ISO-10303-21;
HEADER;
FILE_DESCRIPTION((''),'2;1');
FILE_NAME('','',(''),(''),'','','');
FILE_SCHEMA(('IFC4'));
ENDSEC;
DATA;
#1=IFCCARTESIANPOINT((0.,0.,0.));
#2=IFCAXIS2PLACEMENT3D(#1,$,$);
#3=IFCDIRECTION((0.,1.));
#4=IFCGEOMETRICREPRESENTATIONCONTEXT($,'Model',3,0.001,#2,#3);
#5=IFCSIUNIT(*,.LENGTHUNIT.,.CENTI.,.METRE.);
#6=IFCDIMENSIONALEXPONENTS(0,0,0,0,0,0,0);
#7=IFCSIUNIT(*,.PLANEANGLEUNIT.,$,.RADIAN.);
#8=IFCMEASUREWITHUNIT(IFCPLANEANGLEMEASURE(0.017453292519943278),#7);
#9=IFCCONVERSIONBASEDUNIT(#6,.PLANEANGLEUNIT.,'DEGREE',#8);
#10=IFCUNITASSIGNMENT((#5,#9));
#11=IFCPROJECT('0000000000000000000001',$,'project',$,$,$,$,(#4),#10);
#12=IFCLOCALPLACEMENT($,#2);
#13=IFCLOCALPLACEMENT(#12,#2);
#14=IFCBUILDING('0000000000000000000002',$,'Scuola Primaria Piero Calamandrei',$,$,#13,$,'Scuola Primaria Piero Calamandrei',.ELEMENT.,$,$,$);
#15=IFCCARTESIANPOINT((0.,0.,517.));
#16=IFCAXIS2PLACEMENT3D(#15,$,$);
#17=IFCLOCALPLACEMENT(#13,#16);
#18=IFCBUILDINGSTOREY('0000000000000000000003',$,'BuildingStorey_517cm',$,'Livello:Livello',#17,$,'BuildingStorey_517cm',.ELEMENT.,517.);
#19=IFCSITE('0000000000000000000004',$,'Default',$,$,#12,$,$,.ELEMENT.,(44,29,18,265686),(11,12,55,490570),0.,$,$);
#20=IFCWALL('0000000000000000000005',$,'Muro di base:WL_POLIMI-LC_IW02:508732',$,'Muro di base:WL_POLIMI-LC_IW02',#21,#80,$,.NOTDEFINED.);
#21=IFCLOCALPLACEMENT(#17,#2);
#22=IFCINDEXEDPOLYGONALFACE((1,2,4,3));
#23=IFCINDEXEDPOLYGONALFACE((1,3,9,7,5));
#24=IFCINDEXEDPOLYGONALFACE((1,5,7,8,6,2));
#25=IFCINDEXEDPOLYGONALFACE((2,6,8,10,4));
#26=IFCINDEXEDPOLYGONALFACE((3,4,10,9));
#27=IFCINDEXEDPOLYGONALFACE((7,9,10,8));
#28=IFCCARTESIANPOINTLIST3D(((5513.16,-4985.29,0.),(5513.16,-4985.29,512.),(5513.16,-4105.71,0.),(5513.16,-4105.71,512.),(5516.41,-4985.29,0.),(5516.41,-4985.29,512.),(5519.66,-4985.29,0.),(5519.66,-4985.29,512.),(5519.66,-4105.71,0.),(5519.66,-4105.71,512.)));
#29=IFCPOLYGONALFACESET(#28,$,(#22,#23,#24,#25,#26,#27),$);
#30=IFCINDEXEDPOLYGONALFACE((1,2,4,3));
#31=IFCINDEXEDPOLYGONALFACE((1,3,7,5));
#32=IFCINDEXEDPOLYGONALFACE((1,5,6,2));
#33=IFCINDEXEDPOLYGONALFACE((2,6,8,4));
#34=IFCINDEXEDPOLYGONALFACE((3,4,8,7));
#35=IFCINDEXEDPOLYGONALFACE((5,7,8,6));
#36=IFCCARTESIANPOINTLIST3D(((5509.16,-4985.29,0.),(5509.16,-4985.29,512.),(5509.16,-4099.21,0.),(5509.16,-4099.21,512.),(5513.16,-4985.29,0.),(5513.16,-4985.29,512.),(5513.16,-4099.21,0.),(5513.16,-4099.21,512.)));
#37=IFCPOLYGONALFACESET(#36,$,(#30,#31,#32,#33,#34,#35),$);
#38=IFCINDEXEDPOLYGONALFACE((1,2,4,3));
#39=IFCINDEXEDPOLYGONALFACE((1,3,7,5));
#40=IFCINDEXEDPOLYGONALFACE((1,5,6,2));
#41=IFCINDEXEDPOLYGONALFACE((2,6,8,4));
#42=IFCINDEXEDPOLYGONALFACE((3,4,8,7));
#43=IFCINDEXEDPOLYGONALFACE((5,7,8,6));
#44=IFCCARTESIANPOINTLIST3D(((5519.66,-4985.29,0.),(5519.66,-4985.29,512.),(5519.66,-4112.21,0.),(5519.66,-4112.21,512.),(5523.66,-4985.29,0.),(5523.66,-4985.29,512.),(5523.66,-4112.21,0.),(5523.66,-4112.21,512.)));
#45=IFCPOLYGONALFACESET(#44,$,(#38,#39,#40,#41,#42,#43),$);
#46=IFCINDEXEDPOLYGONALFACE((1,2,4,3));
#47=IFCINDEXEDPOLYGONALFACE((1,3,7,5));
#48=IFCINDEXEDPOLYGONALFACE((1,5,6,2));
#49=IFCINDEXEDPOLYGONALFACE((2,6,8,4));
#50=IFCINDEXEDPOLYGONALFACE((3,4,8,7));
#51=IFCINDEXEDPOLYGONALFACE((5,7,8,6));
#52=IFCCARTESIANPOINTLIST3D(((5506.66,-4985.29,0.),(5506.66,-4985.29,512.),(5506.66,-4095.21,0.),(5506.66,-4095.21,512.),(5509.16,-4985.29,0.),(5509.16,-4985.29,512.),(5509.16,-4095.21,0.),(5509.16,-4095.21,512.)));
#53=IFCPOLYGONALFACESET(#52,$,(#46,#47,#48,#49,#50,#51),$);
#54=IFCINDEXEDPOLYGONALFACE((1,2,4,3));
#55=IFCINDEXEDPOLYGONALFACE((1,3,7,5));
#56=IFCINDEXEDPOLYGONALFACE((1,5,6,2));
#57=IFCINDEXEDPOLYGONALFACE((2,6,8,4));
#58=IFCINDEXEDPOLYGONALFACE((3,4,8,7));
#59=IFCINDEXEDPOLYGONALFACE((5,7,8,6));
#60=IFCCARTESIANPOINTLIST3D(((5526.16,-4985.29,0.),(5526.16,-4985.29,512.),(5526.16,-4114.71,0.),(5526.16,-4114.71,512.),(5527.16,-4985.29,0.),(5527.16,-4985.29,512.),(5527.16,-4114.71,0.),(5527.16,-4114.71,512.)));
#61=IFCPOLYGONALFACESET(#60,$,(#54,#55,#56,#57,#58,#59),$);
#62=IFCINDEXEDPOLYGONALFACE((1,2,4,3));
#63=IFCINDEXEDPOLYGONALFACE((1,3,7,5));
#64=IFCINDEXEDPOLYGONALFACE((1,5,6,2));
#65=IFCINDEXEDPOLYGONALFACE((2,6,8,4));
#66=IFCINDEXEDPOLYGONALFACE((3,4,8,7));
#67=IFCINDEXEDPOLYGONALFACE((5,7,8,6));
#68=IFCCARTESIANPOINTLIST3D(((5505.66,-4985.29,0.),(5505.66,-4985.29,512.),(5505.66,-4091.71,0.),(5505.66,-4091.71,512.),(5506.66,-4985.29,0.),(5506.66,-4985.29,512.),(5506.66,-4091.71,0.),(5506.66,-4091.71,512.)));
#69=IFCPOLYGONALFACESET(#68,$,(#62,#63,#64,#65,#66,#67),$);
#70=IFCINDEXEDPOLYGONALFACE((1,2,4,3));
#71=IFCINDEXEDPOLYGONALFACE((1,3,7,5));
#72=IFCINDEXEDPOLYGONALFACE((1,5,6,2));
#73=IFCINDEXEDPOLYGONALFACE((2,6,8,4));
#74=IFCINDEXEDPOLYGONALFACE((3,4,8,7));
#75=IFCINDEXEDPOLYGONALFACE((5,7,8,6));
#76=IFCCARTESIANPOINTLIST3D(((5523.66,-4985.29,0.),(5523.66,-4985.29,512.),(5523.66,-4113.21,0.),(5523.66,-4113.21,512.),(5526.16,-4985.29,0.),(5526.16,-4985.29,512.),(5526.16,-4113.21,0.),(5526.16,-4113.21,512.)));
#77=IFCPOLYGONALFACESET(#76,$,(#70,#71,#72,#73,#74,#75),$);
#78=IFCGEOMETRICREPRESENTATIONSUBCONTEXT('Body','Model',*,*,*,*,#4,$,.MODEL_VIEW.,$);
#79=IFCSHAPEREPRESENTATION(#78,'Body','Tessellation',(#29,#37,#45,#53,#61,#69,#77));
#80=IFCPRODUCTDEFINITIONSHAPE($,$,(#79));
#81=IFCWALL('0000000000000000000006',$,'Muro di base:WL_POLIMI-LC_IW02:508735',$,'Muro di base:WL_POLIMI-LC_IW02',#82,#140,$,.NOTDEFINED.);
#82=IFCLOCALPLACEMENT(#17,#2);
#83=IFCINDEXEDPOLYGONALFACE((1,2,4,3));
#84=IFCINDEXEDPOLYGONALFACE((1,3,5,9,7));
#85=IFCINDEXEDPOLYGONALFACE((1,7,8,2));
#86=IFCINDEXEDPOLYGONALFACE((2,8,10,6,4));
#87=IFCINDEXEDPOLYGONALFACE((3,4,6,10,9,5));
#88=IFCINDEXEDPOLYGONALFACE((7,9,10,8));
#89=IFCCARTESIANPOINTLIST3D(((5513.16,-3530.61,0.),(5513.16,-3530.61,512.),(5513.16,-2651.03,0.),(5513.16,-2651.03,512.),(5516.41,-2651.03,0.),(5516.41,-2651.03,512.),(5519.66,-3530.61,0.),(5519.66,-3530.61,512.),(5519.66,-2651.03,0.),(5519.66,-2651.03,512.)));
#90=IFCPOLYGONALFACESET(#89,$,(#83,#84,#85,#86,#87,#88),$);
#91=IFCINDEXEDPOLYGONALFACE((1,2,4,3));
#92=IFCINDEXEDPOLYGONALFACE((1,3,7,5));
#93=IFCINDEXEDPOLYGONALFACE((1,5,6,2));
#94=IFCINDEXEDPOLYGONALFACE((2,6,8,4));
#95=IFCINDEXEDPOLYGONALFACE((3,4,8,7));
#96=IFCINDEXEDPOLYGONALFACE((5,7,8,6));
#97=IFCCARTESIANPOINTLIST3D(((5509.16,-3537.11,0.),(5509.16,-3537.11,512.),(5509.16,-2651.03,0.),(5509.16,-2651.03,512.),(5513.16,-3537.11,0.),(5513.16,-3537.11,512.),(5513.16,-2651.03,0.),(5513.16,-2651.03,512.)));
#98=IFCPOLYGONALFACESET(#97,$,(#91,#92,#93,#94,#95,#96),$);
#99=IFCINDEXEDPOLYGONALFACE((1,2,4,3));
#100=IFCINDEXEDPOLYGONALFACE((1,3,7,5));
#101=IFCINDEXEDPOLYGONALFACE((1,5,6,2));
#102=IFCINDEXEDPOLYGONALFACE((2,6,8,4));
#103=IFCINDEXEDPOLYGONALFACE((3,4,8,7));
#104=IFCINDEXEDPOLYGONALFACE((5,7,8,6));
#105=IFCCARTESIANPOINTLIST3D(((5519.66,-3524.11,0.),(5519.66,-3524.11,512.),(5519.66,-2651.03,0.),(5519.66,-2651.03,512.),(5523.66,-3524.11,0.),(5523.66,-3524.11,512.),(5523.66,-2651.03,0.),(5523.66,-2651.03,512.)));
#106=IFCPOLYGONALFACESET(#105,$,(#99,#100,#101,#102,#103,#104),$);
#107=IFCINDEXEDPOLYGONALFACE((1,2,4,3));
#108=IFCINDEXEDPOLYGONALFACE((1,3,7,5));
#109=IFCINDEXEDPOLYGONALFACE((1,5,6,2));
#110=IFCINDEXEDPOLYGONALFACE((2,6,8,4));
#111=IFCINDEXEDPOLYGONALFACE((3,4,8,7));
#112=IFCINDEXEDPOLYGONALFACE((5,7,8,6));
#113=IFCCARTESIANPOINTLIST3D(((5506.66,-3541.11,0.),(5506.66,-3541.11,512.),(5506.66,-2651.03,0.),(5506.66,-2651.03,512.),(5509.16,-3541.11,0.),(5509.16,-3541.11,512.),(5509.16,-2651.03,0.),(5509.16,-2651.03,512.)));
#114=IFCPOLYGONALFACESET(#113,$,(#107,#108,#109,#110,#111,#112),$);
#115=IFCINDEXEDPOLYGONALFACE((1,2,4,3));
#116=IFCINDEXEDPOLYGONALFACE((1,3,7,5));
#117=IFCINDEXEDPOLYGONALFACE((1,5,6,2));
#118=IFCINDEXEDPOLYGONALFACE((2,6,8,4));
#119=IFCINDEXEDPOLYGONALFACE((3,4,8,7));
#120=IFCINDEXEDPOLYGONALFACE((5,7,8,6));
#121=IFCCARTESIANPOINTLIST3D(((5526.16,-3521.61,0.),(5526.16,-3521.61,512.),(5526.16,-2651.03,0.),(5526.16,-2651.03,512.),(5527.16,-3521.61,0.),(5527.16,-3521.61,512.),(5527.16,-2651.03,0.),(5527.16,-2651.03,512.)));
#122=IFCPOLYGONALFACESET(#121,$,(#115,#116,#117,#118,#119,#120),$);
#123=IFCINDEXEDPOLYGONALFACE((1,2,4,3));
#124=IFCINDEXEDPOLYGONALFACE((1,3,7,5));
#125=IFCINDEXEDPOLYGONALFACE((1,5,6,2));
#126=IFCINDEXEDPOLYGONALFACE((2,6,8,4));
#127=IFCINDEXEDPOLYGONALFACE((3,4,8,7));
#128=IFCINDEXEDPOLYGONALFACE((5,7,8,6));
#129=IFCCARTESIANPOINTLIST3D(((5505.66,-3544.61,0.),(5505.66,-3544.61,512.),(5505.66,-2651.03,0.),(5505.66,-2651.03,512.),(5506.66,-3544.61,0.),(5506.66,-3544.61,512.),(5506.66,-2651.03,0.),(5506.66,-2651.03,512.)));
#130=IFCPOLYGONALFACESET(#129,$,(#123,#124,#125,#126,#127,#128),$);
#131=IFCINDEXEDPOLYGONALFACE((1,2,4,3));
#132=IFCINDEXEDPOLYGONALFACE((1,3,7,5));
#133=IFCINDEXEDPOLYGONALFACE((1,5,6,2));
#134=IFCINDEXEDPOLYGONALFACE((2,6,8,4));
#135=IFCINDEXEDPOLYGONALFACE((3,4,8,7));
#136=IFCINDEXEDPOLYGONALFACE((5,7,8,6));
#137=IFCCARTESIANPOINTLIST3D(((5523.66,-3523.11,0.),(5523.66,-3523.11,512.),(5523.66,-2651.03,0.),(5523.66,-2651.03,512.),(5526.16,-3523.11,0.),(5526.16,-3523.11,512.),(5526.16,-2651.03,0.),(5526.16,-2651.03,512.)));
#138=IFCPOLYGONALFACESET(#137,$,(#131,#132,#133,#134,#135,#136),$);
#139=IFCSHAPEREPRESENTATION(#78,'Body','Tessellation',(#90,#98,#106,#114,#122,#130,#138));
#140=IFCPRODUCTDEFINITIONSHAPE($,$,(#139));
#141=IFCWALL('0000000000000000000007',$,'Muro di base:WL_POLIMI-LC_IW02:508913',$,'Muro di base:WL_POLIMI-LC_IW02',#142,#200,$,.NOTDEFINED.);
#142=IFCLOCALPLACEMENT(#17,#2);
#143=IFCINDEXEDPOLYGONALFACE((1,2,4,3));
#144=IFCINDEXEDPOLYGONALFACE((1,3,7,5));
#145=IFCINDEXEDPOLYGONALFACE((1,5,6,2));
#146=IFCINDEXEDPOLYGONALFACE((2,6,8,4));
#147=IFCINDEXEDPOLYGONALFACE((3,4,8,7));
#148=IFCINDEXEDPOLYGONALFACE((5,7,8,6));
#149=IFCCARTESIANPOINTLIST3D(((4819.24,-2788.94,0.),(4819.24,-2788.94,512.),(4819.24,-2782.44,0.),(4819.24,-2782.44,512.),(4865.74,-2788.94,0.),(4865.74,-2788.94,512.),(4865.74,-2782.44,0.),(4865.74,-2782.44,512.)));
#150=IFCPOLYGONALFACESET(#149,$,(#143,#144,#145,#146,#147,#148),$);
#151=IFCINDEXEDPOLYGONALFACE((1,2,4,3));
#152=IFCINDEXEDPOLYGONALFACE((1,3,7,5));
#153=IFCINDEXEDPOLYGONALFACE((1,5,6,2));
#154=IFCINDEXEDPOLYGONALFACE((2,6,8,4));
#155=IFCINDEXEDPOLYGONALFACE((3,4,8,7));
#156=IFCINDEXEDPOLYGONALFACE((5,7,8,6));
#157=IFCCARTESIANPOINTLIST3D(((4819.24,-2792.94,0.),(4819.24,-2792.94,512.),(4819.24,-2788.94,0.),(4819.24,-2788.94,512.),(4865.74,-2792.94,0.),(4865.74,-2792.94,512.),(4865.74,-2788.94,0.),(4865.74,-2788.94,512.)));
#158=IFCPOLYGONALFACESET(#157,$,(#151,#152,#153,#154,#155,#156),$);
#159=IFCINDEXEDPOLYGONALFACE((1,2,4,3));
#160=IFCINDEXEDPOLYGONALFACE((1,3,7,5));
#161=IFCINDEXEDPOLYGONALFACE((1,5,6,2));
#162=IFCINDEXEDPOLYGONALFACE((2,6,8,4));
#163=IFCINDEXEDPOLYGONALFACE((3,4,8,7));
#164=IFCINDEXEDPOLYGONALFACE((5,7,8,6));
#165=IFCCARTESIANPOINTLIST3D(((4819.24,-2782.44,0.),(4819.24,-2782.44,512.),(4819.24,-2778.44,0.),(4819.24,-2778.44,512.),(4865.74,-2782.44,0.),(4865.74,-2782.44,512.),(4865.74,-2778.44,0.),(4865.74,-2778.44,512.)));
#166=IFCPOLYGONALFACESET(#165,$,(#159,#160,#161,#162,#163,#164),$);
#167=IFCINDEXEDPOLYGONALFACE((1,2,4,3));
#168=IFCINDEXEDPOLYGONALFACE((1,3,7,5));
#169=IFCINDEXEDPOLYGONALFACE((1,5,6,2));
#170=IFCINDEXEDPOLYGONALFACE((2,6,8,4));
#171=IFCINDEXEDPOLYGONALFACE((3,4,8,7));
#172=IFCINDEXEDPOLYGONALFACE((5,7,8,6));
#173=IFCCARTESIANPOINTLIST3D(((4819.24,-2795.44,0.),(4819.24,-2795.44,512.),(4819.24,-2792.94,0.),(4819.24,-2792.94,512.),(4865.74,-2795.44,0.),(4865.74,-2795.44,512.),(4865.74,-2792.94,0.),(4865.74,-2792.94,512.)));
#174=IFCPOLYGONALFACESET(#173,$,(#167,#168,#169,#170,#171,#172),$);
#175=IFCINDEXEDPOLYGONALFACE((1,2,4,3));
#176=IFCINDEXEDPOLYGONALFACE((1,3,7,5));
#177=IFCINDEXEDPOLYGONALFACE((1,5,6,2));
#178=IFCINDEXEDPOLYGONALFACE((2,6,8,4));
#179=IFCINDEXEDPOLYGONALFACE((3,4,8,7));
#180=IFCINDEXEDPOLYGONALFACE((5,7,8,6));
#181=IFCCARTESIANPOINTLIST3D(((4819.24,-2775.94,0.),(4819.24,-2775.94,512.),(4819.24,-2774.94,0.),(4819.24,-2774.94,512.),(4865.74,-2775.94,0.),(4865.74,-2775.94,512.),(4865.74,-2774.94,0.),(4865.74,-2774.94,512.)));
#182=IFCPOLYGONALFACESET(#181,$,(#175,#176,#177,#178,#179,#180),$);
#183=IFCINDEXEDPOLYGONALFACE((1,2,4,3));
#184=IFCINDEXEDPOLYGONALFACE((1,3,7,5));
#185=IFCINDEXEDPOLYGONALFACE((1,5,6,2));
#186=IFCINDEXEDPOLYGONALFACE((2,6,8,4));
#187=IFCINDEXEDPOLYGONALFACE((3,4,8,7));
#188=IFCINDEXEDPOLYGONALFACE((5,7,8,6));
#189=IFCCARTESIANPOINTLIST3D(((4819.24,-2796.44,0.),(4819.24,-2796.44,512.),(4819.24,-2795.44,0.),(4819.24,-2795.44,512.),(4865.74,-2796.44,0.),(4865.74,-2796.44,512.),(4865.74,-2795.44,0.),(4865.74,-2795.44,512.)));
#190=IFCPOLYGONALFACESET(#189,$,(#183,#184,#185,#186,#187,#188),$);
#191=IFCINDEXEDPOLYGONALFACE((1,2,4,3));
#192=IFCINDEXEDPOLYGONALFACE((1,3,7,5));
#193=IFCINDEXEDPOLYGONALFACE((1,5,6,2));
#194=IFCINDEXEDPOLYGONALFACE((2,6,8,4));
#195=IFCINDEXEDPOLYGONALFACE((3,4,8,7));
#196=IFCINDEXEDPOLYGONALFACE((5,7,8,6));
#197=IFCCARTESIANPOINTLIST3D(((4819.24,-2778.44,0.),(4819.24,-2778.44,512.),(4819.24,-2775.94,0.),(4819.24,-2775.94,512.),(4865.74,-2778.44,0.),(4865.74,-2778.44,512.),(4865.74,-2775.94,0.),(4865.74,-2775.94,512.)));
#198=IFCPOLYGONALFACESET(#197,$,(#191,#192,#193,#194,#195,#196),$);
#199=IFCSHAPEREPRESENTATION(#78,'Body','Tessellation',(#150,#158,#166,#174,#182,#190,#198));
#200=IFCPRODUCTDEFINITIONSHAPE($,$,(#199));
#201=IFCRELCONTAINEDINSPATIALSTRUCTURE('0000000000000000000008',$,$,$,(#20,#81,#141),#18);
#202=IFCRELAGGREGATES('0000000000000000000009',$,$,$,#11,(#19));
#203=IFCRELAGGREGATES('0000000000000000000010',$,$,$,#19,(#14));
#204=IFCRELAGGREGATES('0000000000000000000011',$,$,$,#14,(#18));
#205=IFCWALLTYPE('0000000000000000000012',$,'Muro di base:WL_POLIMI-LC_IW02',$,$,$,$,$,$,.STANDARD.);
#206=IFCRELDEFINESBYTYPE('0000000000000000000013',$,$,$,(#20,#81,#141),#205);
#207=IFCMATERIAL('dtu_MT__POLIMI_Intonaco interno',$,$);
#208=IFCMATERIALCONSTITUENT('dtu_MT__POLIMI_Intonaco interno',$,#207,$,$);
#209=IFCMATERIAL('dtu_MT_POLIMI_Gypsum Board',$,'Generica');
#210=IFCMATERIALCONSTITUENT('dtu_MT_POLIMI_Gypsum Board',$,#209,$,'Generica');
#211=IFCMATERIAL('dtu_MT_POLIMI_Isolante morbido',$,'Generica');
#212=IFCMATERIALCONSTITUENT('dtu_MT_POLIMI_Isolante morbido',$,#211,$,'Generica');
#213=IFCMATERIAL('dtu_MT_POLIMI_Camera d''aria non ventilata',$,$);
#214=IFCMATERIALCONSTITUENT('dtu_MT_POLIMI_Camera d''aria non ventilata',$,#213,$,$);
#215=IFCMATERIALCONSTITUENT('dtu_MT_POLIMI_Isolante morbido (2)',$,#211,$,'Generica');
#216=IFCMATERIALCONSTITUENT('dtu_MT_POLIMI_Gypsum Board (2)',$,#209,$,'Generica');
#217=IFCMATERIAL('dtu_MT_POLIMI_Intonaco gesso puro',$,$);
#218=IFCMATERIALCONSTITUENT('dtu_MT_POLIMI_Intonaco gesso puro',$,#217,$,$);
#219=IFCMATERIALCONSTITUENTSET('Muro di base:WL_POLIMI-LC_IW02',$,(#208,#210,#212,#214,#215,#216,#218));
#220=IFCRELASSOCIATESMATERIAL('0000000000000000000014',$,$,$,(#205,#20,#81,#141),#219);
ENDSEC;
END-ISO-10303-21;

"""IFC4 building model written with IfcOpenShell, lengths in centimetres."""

from ifc_helpers import new_model, entity, si_unit, converted_unit, direction, frame, origin, place, context, subcontext, project, spatial, indexed_curve, outline, extrude, material, constituent, constituent_set, type_object, element, save


model = new_model("IFC4")

# Units and contexts
model_context = context("Model", 3, precision=0.001, world=origin(), true_north=direction((0.0, 1.0)))
body_context = subcontext(model_context, "Body", "Model", "MODEL_VIEW")
ifc_project = project(units=[si_unit("LENGTHUNIT", "METRE", prefix="CENTI"), converted_unit("PLANEANGLEUNIT", "DEGREE", entity("IfcPlaneAngleMeasure", 0.017453292519943278), si_unit("PLANEANGLEUNIT", "RADIAN"), dimensions=[0, 0, 0, 0, 0, 0, 0])], contexts=[model_context])

# Site, building, storey
site_placement = place(None, origin())
site = spatial("IfcSite", under=ifc_project, at=site_placement, Name="Default", CompositionType="ELEMENT", RefLatitude=(44, 29, 18, 265686), RefLongitude=(11, 12, 55, 490570), RefElevation=0.0)
building_placement = place(site_placement, origin())
building = spatial("IfcBuilding", under=site, at=building_placement, Name="Scuola Primaria Piero Calamandrei", LongName="Scuola Primaria Piero Calamandrei", CompositionType="ELEMENT")
storey_placement = place(building_placement, frame((0.0, 0.0, 517.0)))
storey = spatial("IfcBuildingStorey", under=building, at=storey_placement, Name="BuildingStorey_517cm", ObjectType="Livello:Livello", LongName="BuildingStorey_517cm", CompositionType="ELEMENT", Elevation=517.0)

# Shared definitions
ifc_material_1 = material(Name="dtu_MT_POLIMI_Isolante morbido", Category="Generica")
ifc_material_2 = material(Name="dtu_MT_POLIMI_Gypsum Board", Category="Generica")
ifc_material_3 = material(Name="dtu_MT__POLIMI_Intonaco interno")

# Shared definitions
ifc_constituent_1 = constituent(ifc_material_3, Name="dtu_MT__POLIMI_Intonaco interno")
ifc_constituent_2 = constituent(ifc_material_2, Name="dtu_MT_POLIMI_Gypsum Board", Category="Generica")
ifc_constituent_3 = constituent(ifc_material_1, Name="dtu_MT_POLIMI_Isolante morbido", Category="Generica")
ifc_material_4 = material(Name="dtu_MT_POLIMI_Camera d'aria non ventilata")
ifc_constituent_4 = constituent(ifc_material_4, Name="dtu_MT_POLIMI_Camera d'aria non ventilata")
ifc_constituent_5 = constituent(ifc_material_1, Name="dtu_MT_POLIMI_Isolante morbido (2)", Category="Generica")
ifc_constituent_6 = constituent(ifc_material_2, Name="dtu_MT_POLIMI_Gypsum Board (2)", Category="Generica")
ifc_material_5 = material(Name="dtu_MT_POLIMI_Intonaco gesso puro")
ifc_constituent_7 = constituent(ifc_material_5, Name="dtu_MT_POLIMI_Intonaco gesso puro")
ifc_constituent_set_1 = constituent_set(constituents=[ifc_constituent_1, ifc_constituent_2, ifc_constituent_3, ifc_constituent_4, ifc_constituent_5, ifc_constituent_6, ifc_constituent_7], Name="Muro di base:WL_POLIMI-LC_IW02")
wall_type_1 = type_object("IfcWallType", Name="Muro di base:WL_POLIMI-LC_IW02", PredefinedType="STANDARD", material=ifc_constituent_set_1)

# Walls
wall_1_placement = place(storey_placement, frame((5516.41, -4985.29, 0.0), z_axis=(0.0, 0.0, 1.0), x_axis=(0.0, 1.0, 0.0)))
element("IfcWall", 1, at=wall_1_placement, inside=storey, type_object=wall_type_1, material=ifc_constituent_set_1, Name="Muro di base:WL_POLIMI-LC_IW02:508732", ObjectType="Muro di base:WL_POLIMI-LC_IW02", PredefinedType="NOTDEFINED", context=body_context, shape_type="SweptSolid", body=[
    extrude(outline(indexed_curve([(-351.83, -3.25), (527.74, -3.25), (527.74, 3.25), (-351.83, 3.25), (-351.83, 0.0), (-351.83, -3.25)], self_intersect=False)), frame((351.83, 0.0, 0.0)), (0.0, 0.0, 1.0), 512.0),
    extrude(outline(indexed_curve([(-443.04, -2.0), (443.04, -2.0), (443.04, 2.0), (-443.04, 2.0), (-443.04, -2.0)], self_intersect=False)), frame((443.04, 5.25, 0.0)), (0.0, 0.0, 1.0), 512.0),
    extrude(outline(indexed_curve([(-436.54, -2.0), (436.54, -2.0), (436.54, 2.0), (-436.54, 2.0), (-436.54, -2.0)], self_intersect=False)), frame((436.54, -5.25, 0.0)), (0.0, 0.0, 1.0), 512.0),
    extrude(outline(indexed_curve([(-445.04, -1.25), (445.04, -1.25), (445.04, 1.25), (-445.04, 1.25), (-445.04, -1.25)], self_intersect=False)), frame((445.04, 8.5, 0.0)), (0.0, 0.0, 1.0), 512.0),
    extrude(outline(indexed_curve([(-0.5, -435.29), (0.5, -435.29), (0.5, 435.29), (-0.5, 435.29), (-0.5, -435.29)], self_intersect=False)), frame((435.29, -10.25, 0.0), z_axis=(0.0, 0.0, 1.0), x_axis=(0.0, 1.0, 0.0)), (0.0, 0.0, 1.0), 512.0),
    extrude(outline(indexed_curve([(-0.5, -446.79), (0.5, -446.79), (0.5, 446.79), (-0.5, 446.79), (-0.5, -446.79)], self_intersect=False)), frame((446.79, 10.25, 0.0), z_axis=(0.0, 0.0, 1.0), x_axis=(0.0, -1.0, 0.0)), (0.0, 0.0, 1.0), 512.0),
    extrude(outline(indexed_curve([(-436.04, -1.25), (436.04, -1.25), (436.04, 1.25), (-436.04, 1.25), (-436.04, -1.25)], self_intersect=False)), frame((436.04, -8.5, 0.0)), (0.0, 0.0, 1.0), 512.0),
])
wall_2_placement = place(storey_placement, frame((5516.41, -3521.61, 0.0), z_axis=(0.0, 0.0, 1.0), x_axis=(0.0, 1.0, 0.0)))
element("IfcWall", 2, at=wall_2_placement, inside=storey, type_object=wall_type_1, material=ifc_constituent_set_1, Name="Muro di base:WL_POLIMI-LC_IW02:508735", ObjectType="Muro di base:WL_POLIMI-LC_IW02", PredefinedType="NOTDEFINED", context=body_context, shape_type="SweptSolid", body=[
    extrude(outline(indexed_curve([(-527.74, -3.25), (351.83, -3.25), (351.83, 0.0), (351.83, 3.25), (-527.74, 3.25), (-527.74, -3.25)], self_intersect=False)), frame((518.74, 0.0, 0.0)), (0.0, 0.0, 1.0), 512.0),
    extrude(outline(indexed_curve([(-443.04, -2.0), (443.04, -2.0), (443.04, 2.0), (-443.04, 2.0), (-443.04, -2.0)], self_intersect=False)), frame((427.54, 5.25, 0.0)), (0.0, 0.0, 1.0), 512.0),
    extrude(outline(indexed_curve([(-436.54, -2.0), (436.54, -2.0), (436.54, 2.0), (-436.54, 2.0), (-436.54, -2.0)], self_intersect=False)), frame((434.04, -5.25, 0.0)), (0.0, 0.0, 1.0), 512.0),
    extrude(outline(indexed_curve([(-445.04, -1.25), (445.04, -1.25), (445.04, 1.25), (-445.04, 1.25), (-445.04, -1.25)], self_intersect=False)), frame((425.54, 8.5, 0.0)), (0.0, 0.0, 1.0), 512.0),
    extrude(outline(indexed_curve([(-0.5, -435.29), (0.5, -435.29), (0.5, 435.29), (-0.5, 435.29), (-0.5, -435.29)], self_intersect=False)), frame((435.29, -10.25, 0.0), z_axis=(0.0, 0.0, 1.0), x_axis=(0.0, 1.0, 0.0)), (0.0, 0.0, 1.0), 512.0),
    extrude(outline(indexed_curve([(-0.5, -446.79), (0.5, -446.79), (0.5, 446.79), (-0.5, 446.79), (-0.5, -446.79)], self_intersect=False)), frame((423.79, 10.25, 0.0), z_axis=(0.0, 0.0, 1.0), x_axis=(0.0, -1.0, 0.0)), (0.0, 0.0, 1.0), 512.0),
    extrude(outline(indexed_curve([(-436.04, -1.25), (436.04, -1.25), (436.04, 1.25), (-436.04, 1.25), (-436.04, -1.25)], self_intersect=False)), frame((434.54, -8.5, 0.0)), (0.0, 0.0, 1.0), 512.0),
])
wall_3_placement = place(storey_placement, frame((4865.74, -2785.69, 0.0), z_axis=(0.0, 0.0, 1.0), x_axis=(-1.0, 0.0, 0.0)))
element("IfcWall", 3, at=wall_3_placement, inside=storey, type_object=wall_type_1, material=ifc_constituent_set_1, Name="Muro di base:WL_POLIMI-LC_IW02:508913", ObjectType="Muro di base:WL_POLIMI-LC_IW02", PredefinedType="NOTDEFINED", context=body_context, shape_type="SweptSolid", body=[
    extrude(outline(indexed_curve([(-23.25, -3.25), (23.25, -3.25), (23.25, 3.25), (-23.25, 3.25), (-23.25, -3.25)], self_intersect=False)), frame((23.25, 0.0, 0.0)), (0.0, 0.0, 1.0), 512.0),
    extrude(outline(indexed_curve([(-23.25, -2.0), (23.25, -2.0), (23.25, 2.0), (-23.25, 2.0), (-23.25, -2.0)], self_intersect=False)), frame((23.25, 5.25, 0.0)), (0.0, 0.0, 1.0), 512.0),
    extrude(outline(indexed_curve([(-23.25, -2.0), (23.25, -2.0), (23.25, 2.0), (-23.25, 2.0), (-23.25, -2.0)], self_intersect=False)), frame((23.25, -5.25, 0.0)), (0.0, 0.0, 1.0), 512.0),
    extrude(outline(indexed_curve([(-23.25, -1.25), (23.25, -1.25), (23.25, 1.25), (-23.25, 1.25), (-23.25, -1.25)], self_intersect=False)), frame((23.25, 8.5, 0.0)), (0.0, 0.0, 1.0), 512.0),
    extrude(outline(indexed_curve([(-0.5, -23.25), (0.5, -23.25), (0.5, 23.25), (-0.5, 23.25), (-0.5, -23.25)], self_intersect=False)), frame((23.25, -10.25, 0.0), z_axis=(0.0, 0.0, 1.0), x_axis=(0.0, 1.0, 0.0)), (0.0, 0.0, 1.0), 512.0),
    extrude(outline(indexed_curve([(-0.5, -23.25), (0.5, -23.25), (0.5, 23.25), (-0.5, 23.25), (-0.5, -23.25)], self_intersect=False)), frame((23.25, 10.25, 0.0), z_axis=(0.0, 0.0, 1.0), x_axis=(0.0, -1.0, 0.0)), (0.0, 0.0, 1.0), 512.0),
    extrude(outline(indexed_curve([(-23.25, -1.25), (23.25, -1.25), (23.25, 1.25), (-23.25, 1.25), (-23.25, -1.25)], self_intersect=False)), frame((23.25, -8.5, 0.0)), (0.0, 0.0, 1.0), 512.0),
])

save(model, "model.ifc")
